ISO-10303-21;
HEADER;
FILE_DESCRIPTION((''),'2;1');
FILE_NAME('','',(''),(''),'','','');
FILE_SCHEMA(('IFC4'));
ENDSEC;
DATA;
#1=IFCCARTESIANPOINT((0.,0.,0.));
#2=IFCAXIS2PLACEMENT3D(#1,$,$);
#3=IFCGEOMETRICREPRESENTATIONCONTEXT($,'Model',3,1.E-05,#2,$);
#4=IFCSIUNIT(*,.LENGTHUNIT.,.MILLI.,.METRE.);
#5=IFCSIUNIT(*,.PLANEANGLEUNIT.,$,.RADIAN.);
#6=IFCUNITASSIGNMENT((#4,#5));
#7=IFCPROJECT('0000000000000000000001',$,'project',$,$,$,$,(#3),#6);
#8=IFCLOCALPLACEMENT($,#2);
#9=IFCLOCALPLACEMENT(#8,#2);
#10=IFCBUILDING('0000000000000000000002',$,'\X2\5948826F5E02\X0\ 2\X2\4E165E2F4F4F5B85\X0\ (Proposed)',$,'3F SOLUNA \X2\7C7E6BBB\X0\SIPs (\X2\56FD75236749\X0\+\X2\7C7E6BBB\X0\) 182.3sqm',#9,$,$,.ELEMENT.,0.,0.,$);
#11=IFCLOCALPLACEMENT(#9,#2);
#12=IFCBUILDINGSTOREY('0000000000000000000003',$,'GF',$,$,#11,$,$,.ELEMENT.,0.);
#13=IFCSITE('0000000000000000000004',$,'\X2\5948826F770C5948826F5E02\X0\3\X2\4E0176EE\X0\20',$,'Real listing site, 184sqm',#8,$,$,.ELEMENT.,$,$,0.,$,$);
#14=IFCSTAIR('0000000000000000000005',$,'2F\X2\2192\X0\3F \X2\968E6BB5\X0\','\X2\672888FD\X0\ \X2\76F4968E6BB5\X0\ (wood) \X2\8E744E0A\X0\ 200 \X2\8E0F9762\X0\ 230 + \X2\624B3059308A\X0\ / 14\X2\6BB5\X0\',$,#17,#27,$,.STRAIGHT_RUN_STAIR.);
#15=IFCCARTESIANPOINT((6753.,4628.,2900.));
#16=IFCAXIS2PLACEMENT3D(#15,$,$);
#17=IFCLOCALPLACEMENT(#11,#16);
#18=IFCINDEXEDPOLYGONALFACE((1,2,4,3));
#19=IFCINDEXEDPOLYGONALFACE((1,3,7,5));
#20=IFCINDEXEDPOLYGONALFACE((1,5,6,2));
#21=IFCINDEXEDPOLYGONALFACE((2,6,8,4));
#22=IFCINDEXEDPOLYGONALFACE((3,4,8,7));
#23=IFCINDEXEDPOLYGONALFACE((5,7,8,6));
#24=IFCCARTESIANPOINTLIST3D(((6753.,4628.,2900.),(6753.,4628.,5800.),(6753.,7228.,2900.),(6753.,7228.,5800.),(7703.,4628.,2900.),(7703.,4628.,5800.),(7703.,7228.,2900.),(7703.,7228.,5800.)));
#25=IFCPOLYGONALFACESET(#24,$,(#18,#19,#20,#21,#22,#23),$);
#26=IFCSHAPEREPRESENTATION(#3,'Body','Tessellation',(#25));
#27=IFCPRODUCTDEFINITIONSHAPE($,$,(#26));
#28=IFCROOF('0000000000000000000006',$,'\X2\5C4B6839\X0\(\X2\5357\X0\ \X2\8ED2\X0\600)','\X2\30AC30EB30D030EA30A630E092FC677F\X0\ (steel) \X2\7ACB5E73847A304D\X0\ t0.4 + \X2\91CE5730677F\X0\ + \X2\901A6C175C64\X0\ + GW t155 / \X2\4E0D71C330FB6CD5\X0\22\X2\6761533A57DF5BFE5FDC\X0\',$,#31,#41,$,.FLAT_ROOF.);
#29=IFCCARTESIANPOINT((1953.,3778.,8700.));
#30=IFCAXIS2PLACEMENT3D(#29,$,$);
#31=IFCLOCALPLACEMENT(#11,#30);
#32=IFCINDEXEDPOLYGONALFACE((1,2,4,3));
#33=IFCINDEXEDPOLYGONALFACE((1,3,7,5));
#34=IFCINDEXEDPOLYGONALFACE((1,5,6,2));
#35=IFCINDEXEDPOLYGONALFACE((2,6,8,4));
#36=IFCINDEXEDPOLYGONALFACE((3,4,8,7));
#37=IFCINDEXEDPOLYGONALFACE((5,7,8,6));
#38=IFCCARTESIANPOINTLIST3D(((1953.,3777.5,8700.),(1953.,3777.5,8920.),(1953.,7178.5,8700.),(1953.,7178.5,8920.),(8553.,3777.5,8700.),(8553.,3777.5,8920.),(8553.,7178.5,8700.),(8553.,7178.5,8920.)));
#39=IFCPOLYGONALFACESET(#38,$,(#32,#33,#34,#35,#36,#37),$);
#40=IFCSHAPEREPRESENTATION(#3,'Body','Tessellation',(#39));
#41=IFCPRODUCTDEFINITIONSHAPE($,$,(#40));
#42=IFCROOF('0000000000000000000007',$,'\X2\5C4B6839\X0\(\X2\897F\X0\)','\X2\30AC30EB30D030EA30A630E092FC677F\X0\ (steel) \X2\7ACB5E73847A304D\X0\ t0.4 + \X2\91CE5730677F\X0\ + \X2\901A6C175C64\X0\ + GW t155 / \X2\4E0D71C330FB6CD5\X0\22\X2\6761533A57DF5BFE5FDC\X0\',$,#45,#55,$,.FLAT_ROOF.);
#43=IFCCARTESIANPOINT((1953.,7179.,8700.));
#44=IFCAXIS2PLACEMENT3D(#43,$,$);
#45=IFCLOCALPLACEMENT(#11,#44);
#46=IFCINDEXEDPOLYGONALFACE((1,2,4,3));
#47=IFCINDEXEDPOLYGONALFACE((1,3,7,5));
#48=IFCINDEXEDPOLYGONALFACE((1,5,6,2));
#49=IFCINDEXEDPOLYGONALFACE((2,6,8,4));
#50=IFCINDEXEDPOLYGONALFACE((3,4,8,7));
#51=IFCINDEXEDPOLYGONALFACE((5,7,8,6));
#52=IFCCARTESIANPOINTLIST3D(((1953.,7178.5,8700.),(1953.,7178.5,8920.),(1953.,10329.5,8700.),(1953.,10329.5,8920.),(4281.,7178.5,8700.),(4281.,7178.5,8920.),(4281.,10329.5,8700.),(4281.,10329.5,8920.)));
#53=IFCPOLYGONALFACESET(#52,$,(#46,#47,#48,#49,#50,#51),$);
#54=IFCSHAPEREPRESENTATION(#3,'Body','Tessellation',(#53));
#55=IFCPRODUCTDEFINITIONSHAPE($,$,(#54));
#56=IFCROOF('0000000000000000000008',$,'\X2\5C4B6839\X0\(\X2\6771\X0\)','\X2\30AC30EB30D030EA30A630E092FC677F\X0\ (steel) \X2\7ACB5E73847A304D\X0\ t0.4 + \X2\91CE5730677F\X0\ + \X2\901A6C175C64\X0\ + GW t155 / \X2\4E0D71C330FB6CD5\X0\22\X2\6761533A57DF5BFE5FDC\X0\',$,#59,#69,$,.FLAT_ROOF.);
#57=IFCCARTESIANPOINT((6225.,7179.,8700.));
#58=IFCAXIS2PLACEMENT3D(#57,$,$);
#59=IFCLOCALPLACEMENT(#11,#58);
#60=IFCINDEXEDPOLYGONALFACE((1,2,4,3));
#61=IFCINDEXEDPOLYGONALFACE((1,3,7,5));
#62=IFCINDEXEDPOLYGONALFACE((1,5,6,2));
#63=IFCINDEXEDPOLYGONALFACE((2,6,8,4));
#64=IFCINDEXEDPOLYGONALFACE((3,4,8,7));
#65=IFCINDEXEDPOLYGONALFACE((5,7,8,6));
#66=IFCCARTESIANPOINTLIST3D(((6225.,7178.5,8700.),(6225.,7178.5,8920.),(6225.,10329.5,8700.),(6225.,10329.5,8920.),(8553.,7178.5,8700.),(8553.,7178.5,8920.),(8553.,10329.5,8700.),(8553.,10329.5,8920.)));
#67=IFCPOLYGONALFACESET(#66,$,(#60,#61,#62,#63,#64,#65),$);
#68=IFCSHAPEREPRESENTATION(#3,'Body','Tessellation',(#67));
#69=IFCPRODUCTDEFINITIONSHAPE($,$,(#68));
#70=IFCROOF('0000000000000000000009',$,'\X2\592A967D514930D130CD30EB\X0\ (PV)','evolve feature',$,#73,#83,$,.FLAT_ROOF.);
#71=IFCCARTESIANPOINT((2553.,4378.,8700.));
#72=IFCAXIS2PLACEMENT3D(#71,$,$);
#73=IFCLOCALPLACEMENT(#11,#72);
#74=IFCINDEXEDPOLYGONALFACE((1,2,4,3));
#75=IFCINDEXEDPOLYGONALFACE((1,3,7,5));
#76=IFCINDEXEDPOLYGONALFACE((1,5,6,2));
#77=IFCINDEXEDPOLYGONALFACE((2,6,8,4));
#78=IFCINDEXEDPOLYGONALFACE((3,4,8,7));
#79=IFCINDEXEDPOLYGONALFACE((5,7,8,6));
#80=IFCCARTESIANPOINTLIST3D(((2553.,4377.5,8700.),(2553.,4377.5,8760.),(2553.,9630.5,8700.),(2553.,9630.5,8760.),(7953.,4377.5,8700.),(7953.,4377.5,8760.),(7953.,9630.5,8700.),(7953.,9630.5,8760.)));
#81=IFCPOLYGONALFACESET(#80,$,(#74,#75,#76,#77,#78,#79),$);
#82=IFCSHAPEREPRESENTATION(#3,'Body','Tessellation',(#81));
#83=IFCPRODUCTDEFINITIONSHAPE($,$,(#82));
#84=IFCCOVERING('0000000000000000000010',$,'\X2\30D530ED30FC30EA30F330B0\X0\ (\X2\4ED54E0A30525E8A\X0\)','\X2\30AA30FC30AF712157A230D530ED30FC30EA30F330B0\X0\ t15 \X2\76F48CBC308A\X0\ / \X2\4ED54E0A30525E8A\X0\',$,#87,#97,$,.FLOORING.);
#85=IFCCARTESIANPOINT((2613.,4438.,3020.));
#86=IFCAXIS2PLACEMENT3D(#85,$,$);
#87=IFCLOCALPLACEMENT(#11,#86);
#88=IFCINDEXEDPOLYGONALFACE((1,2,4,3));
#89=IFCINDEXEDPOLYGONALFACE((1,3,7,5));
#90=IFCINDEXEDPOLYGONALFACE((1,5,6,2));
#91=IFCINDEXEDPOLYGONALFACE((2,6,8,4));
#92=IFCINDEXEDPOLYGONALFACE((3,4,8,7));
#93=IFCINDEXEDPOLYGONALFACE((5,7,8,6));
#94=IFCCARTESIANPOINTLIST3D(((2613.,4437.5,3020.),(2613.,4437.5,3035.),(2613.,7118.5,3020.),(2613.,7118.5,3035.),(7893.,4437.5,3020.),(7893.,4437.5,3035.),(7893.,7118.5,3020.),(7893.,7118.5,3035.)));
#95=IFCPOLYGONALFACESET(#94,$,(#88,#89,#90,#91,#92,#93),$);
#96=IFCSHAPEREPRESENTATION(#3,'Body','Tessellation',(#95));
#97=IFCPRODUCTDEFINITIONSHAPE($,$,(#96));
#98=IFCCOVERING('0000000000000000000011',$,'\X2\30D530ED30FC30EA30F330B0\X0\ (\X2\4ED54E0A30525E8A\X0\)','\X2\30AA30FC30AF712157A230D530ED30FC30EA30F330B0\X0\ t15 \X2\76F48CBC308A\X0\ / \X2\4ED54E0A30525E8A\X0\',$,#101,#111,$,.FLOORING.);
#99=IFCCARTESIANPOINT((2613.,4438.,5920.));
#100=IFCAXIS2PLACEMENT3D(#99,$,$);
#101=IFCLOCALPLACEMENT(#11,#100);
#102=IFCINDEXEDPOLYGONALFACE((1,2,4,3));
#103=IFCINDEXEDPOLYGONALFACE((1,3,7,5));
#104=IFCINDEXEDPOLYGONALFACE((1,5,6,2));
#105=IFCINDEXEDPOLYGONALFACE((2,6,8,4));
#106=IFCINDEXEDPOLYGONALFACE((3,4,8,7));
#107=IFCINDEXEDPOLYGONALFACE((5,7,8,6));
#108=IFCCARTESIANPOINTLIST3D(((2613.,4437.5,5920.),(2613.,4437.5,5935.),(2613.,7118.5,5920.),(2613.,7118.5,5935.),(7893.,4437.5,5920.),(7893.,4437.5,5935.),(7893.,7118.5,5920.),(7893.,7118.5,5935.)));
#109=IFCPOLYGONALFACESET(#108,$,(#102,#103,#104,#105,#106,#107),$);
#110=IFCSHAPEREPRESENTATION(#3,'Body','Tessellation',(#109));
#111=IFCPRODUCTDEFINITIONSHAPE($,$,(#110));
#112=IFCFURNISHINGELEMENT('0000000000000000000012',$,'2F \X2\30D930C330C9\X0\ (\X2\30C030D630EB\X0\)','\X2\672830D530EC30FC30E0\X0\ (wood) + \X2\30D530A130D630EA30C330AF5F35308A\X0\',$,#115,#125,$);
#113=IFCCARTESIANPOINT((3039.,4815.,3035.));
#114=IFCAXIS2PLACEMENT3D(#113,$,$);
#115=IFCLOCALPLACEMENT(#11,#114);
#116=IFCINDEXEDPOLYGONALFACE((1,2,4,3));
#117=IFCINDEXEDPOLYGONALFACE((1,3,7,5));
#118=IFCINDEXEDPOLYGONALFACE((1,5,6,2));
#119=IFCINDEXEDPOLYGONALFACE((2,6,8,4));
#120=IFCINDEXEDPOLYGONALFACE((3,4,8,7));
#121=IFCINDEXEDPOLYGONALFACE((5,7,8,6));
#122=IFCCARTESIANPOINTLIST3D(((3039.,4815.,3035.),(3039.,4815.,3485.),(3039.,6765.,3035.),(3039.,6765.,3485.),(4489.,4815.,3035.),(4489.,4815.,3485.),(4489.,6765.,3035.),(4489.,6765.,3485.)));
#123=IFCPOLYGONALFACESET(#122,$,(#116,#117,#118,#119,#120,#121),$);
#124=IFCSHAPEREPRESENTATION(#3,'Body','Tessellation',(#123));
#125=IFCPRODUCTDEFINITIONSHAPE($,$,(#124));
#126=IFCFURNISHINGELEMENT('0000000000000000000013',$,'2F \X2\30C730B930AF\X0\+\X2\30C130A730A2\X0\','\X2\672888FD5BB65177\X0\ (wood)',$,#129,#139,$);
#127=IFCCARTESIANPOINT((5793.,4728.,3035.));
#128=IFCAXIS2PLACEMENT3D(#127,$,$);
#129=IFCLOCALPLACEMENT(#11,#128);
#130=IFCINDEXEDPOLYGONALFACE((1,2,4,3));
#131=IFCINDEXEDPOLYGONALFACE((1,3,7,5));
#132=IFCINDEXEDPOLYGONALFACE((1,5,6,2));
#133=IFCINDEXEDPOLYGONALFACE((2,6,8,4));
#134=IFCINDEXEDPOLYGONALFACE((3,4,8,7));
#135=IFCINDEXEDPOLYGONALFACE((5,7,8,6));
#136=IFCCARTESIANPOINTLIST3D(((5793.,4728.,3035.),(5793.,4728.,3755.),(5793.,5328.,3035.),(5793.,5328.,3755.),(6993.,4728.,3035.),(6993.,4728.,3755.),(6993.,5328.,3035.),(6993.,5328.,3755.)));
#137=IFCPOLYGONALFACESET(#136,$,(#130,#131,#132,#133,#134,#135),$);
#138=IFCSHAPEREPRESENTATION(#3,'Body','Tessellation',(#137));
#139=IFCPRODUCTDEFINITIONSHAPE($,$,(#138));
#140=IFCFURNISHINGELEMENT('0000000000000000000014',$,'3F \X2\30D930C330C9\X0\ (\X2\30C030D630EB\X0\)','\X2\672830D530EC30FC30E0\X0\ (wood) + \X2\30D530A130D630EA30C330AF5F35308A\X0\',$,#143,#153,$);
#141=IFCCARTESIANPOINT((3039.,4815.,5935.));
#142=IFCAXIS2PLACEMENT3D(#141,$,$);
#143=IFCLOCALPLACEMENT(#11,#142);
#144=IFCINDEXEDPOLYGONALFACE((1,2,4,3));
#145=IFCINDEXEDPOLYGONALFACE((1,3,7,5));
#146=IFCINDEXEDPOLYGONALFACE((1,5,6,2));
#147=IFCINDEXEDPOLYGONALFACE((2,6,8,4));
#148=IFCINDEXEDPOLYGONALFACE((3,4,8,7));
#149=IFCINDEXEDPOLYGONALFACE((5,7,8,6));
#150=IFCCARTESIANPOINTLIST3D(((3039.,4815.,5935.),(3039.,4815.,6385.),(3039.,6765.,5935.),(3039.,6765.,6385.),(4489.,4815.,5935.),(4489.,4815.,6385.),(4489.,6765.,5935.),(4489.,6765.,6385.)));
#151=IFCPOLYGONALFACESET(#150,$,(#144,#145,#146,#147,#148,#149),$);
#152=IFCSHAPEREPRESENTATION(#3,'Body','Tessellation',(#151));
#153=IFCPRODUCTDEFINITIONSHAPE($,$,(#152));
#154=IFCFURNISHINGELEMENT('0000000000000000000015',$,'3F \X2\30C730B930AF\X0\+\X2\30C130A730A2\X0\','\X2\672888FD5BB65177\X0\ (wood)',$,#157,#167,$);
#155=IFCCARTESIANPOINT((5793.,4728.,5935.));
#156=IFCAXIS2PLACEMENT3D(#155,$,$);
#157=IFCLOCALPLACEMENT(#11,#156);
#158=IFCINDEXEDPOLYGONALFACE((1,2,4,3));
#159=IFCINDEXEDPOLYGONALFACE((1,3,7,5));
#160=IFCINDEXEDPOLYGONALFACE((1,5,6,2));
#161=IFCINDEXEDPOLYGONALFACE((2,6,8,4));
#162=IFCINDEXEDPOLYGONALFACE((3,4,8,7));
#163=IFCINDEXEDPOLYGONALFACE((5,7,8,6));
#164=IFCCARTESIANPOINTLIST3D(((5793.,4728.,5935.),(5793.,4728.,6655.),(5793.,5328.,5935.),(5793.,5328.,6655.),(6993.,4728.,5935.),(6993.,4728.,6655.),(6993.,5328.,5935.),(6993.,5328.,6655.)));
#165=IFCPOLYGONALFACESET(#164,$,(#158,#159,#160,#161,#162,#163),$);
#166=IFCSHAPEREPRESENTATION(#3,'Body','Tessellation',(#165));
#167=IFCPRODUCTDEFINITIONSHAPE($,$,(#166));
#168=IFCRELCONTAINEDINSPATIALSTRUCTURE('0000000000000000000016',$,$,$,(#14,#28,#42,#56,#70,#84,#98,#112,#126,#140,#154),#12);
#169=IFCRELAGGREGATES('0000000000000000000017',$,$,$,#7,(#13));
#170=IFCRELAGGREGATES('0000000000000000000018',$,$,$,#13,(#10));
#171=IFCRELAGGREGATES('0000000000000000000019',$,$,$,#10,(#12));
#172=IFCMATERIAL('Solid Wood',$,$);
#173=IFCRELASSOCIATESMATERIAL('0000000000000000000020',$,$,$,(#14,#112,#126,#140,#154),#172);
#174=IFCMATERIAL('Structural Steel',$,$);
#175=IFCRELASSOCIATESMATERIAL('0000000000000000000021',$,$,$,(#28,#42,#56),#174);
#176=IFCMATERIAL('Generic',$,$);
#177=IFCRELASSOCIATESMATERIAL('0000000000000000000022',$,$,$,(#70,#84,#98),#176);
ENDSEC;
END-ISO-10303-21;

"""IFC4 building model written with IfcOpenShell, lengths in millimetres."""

from ifc_helpers import new_model, si_unit, frame, frame_2d, origin, place, context, project, spatial, rectangle, extrude, material, element, save


model = new_model("IFC4")

# Units and contexts
model_context = context("Model", 3, precision=1e-05, world=origin())
ifc_project = project(units=[si_unit("LENGTHUNIT", "METRE", prefix="MILLI"), si_unit("PLANEANGLEUNIT", "RADIAN")], contexts=[model_context])

# Site, building, storey
site_placement = place(None, origin())
site = spatial("IfcSite", under=ifc_project, at=site_placement, Name="奈良県奈良市3丁目20", ObjectType="Real listing site, 184sqm", CompositionType="ELEMENT", RefElevation=0.0)
building_placement = place(site_placement, origin())
building = spatial("IfcBuilding", under=site, at=building_placement, Name="奈良市 2世帯住宅 (Proposed)", ObjectType="3F SOLUNA 籾殻SIPs (国産杉+籾殻) 182.3sqm", CompositionType="ELEMENT", ElevationOfRefHeight=0.0, ElevationOfTerrain=0.0)
storey_placement = place(building_placement, origin())
storey = spatial("IfcBuildingStorey", under=building, at=storey_placement, Name="GF", CompositionType="ELEMENT", Elevation=0.0)

# Shared definitions
ifc_material_1 = material(Name="Solid Wood")

# Stair
stair_placement = place(storey_placement, frame((6753.0, 4628.0, 2900.0)))
element("IfcStair", 1, at=stair_placement, inside=storey, material=ifc_material_1, Name="2F→3F 階段", Description="木製 直階段 (wood) 蹴上 200 踏面 230 + 手すり / 14段", PredefinedType="STRAIGHT_RUN_STAIR", context=model_context, shape_type="SweptSolid", body=[
    extrude(rectangle(XDim=950.0, YDim=2600.0, at=frame_2d((475.0, 1300.0))), frame((6753.0, 4628.0, 2900.0)), (0.0, 0.0, 1.0), 2900.0),
])

# Roofs
ifc_material_2 = material(Name="Structural Steel")
roof_1_placement = place(storey_placement, frame((1953.0, 3778.0, 8700.0)))
element("IfcRoof", 2, at=roof_1_placement, inside=storey, material=ifc_material_2, Name="屋根(南 軒600)", Description="ガルバリウム鋼板 (steel) 立平葺き t0.4 + 野地板 + 通気層 + GW t155 / 不燃・法22条区域対応", PredefinedType="FLAT_ROOF", context=model_context, shape_type="SweptSolid", body=[
    extrude(rectangle(XDim=6600.0, YDim=3401.0, at=frame_2d((3300.0, 1700.0))), frame((1953.0, 3778.0, 8700.0)), (0.0, 0.0, 1.0), 220.0),
])
roof_2_placement = place(storey_placement, frame((1953.0, 7179.0, 8700.0)))
element("IfcRoof", 3, at=roof_2_placement, inside=storey, material=ifc_material_2, Name="屋根(西)", Description="ガルバリウム鋼板 (steel) 立平葺き t0.4 + 野地板 + 通気層 + GW t155 / 不燃・法22条区域対応", PredefinedType="FLAT_ROOF", context=model_context, shape_type="SweptSolid", body=[
    extrude(rectangle(XDim=2328.0, YDim=3151.0, at=frame_2d((1164.0, 1575.0))), frame((1953.0, 7179.0, 8700.0)), (0.0, 0.0, 1.0), 220.0),
])
roof_3_placement = place(storey_placement, frame((6225.0, 7179.0, 8700.0)))
element("IfcRoof", 4, at=roof_3_placement, inside=storey, material=ifc_material_2, Name="屋根(東)", Description="ガルバリウム鋼板 (steel) 立平葺き t0.4 + 野地板 + 通気層 + GW t155 / 不燃・法22条区域対応", PredefinedType="FLAT_ROOF", context=model_context, shape_type="SweptSolid", body=[
    extrude(rectangle(XDim=2328.0, YDim=3151.0, at=frame_2d((1164.0, 1575.0))), frame((6225.0, 7179.0, 8700.0)), (0.0, 0.0, 1.0), 220.0),
])
ifc_material_3 = material(Name="Generic")
roof_4_placement = place(storey_placement, frame((2553.0, 4378.0, 8700.0)))
element("IfcRoof", 5, at=roof_4_placement, inside=storey, material=ifc_material_3, Name="太陽光パネル (PV)", Description="evolve feature", PredefinedType="FLAT_ROOF", context=model_context, shape_type="SweptSolid", body=[
    extrude(rectangle(XDim=5400.0, YDim=5253.0, at=frame_2d((2700.0, 2626.0))), frame((2553.0, 4378.0, 8700.0)), (0.0, 0.0, 1.0), 60.0),
])

# Coverings
covering_1_placement = place(storey_placement, frame((2613.0, 4438.0, 3020.0)))
element("IfcCovering", 6, at=covering_1_placement, inside=storey, material=ifc_material_3, Name="フローリング (仕上げ床)", Description="オーク無垢フローリング t15 直貼り / 仕上げ床", PredefinedType="FLOORING", context=model_context, shape_type="SweptSolid", body=[
    extrude(rectangle(XDim=5280.0, YDim=2681.0, at=frame_2d((2640.0, 1340.0))), frame((2613.0, 4438.0, 3020.0)), (0.0, 0.0, 1.0), 15.0),
])
covering_2_placement = place(storey_placement, frame((2613.0, 4438.0, 5920.0)))
element("IfcCovering", 7, at=covering_2_placement, inside=storey, material=ifc_material_3, Name="フローリング (仕上げ床)", Description="オーク無垢フローリング t15 直貼り / 仕上げ床", PredefinedType="FLOORING", context=model_context, shape_type="SweptSolid", body=[
    extrude(rectangle(XDim=5280.0, YDim=2681.0, at=frame_2d((2640.0, 1340.0))), frame((2613.0, 4438.0, 5920.0)), (0.0, 0.0, 1.0), 15.0),
])

# Furnishing elements
furnishing_1_placement = place(storey_placement, frame((3039.0, 4815.0, 3035.0)))
element("IfcFurnishingElement", 8, at=furnishing_1_placement, inside=storey, material=ifc_material_1, Name="2F ベッド (ダブル)", Description="木フレーム (wood) + ファブリック張り", context=model_context, shape_type="SweptSolid", body=[
    extrude(rectangle(XDim=1450.0, YDim=1950.0, at=frame_2d((725.0, 975.0))), frame((3039.0, 4815.0, 3035.0)), (0.0, 0.0, 1.0), 450.0),
])
furnishing_2_placement = place(storey_placement, frame((5793.0, 4728.0, 3035.0)))
element("IfcFurnishingElement", 9, at=furnishing_2_placement, inside=storey, material=ifc_material_1, Name="2F デスク+チェア", Description="木製家具 (wood)", context=model_context, shape_type="SweptSolid", body=[
    extrude(rectangle(XDim=1200.0, YDim=600.0, at=frame_2d((600.0, 300.0))), frame((5793.0, 4728.0, 3035.0)), (0.0, 0.0, 1.0), 720.0),
])
furnishing_3_placement = place(storey_placement, frame((3039.0, 4815.0, 5935.0)))
element("IfcFurnishingElement", 10, at=furnishing_3_placement, inside=storey, material=ifc_material_1, Name="3F ベッド (ダブル)", Description="木フレーム (wood) + ファブリック張り", context=model_context, shape_type="SweptSolid", body=[
    extrude(rectangle(XDim=1450.0, YDim=1950.0, at=frame_2d((725.0, 975.0))), frame((3039.0, 4815.0, 5935.0)), (0.0, 0.0, 1.0), 450.0),
])
furnishing_4_placement = place(storey_placement, frame((5793.0, 4728.0, 5935.0)))
element("IfcFurnishingElement", 11, at=furnishing_4_placement, inside=storey, material=ifc_material_1, Name="3F デスク+チェア", Description="木製家具 (wood)", context=model_context, shape_type="SweptSolid", body=[
    extrude(rectangle(XDim=1200.0, YDim=600.0, at=frame_2d((600.0, 300.0))), frame((5793.0, 4728.0, 5935.0)), (0.0, 0.0, 1.0), 720.0),
])

save(model, "model.ifc")
